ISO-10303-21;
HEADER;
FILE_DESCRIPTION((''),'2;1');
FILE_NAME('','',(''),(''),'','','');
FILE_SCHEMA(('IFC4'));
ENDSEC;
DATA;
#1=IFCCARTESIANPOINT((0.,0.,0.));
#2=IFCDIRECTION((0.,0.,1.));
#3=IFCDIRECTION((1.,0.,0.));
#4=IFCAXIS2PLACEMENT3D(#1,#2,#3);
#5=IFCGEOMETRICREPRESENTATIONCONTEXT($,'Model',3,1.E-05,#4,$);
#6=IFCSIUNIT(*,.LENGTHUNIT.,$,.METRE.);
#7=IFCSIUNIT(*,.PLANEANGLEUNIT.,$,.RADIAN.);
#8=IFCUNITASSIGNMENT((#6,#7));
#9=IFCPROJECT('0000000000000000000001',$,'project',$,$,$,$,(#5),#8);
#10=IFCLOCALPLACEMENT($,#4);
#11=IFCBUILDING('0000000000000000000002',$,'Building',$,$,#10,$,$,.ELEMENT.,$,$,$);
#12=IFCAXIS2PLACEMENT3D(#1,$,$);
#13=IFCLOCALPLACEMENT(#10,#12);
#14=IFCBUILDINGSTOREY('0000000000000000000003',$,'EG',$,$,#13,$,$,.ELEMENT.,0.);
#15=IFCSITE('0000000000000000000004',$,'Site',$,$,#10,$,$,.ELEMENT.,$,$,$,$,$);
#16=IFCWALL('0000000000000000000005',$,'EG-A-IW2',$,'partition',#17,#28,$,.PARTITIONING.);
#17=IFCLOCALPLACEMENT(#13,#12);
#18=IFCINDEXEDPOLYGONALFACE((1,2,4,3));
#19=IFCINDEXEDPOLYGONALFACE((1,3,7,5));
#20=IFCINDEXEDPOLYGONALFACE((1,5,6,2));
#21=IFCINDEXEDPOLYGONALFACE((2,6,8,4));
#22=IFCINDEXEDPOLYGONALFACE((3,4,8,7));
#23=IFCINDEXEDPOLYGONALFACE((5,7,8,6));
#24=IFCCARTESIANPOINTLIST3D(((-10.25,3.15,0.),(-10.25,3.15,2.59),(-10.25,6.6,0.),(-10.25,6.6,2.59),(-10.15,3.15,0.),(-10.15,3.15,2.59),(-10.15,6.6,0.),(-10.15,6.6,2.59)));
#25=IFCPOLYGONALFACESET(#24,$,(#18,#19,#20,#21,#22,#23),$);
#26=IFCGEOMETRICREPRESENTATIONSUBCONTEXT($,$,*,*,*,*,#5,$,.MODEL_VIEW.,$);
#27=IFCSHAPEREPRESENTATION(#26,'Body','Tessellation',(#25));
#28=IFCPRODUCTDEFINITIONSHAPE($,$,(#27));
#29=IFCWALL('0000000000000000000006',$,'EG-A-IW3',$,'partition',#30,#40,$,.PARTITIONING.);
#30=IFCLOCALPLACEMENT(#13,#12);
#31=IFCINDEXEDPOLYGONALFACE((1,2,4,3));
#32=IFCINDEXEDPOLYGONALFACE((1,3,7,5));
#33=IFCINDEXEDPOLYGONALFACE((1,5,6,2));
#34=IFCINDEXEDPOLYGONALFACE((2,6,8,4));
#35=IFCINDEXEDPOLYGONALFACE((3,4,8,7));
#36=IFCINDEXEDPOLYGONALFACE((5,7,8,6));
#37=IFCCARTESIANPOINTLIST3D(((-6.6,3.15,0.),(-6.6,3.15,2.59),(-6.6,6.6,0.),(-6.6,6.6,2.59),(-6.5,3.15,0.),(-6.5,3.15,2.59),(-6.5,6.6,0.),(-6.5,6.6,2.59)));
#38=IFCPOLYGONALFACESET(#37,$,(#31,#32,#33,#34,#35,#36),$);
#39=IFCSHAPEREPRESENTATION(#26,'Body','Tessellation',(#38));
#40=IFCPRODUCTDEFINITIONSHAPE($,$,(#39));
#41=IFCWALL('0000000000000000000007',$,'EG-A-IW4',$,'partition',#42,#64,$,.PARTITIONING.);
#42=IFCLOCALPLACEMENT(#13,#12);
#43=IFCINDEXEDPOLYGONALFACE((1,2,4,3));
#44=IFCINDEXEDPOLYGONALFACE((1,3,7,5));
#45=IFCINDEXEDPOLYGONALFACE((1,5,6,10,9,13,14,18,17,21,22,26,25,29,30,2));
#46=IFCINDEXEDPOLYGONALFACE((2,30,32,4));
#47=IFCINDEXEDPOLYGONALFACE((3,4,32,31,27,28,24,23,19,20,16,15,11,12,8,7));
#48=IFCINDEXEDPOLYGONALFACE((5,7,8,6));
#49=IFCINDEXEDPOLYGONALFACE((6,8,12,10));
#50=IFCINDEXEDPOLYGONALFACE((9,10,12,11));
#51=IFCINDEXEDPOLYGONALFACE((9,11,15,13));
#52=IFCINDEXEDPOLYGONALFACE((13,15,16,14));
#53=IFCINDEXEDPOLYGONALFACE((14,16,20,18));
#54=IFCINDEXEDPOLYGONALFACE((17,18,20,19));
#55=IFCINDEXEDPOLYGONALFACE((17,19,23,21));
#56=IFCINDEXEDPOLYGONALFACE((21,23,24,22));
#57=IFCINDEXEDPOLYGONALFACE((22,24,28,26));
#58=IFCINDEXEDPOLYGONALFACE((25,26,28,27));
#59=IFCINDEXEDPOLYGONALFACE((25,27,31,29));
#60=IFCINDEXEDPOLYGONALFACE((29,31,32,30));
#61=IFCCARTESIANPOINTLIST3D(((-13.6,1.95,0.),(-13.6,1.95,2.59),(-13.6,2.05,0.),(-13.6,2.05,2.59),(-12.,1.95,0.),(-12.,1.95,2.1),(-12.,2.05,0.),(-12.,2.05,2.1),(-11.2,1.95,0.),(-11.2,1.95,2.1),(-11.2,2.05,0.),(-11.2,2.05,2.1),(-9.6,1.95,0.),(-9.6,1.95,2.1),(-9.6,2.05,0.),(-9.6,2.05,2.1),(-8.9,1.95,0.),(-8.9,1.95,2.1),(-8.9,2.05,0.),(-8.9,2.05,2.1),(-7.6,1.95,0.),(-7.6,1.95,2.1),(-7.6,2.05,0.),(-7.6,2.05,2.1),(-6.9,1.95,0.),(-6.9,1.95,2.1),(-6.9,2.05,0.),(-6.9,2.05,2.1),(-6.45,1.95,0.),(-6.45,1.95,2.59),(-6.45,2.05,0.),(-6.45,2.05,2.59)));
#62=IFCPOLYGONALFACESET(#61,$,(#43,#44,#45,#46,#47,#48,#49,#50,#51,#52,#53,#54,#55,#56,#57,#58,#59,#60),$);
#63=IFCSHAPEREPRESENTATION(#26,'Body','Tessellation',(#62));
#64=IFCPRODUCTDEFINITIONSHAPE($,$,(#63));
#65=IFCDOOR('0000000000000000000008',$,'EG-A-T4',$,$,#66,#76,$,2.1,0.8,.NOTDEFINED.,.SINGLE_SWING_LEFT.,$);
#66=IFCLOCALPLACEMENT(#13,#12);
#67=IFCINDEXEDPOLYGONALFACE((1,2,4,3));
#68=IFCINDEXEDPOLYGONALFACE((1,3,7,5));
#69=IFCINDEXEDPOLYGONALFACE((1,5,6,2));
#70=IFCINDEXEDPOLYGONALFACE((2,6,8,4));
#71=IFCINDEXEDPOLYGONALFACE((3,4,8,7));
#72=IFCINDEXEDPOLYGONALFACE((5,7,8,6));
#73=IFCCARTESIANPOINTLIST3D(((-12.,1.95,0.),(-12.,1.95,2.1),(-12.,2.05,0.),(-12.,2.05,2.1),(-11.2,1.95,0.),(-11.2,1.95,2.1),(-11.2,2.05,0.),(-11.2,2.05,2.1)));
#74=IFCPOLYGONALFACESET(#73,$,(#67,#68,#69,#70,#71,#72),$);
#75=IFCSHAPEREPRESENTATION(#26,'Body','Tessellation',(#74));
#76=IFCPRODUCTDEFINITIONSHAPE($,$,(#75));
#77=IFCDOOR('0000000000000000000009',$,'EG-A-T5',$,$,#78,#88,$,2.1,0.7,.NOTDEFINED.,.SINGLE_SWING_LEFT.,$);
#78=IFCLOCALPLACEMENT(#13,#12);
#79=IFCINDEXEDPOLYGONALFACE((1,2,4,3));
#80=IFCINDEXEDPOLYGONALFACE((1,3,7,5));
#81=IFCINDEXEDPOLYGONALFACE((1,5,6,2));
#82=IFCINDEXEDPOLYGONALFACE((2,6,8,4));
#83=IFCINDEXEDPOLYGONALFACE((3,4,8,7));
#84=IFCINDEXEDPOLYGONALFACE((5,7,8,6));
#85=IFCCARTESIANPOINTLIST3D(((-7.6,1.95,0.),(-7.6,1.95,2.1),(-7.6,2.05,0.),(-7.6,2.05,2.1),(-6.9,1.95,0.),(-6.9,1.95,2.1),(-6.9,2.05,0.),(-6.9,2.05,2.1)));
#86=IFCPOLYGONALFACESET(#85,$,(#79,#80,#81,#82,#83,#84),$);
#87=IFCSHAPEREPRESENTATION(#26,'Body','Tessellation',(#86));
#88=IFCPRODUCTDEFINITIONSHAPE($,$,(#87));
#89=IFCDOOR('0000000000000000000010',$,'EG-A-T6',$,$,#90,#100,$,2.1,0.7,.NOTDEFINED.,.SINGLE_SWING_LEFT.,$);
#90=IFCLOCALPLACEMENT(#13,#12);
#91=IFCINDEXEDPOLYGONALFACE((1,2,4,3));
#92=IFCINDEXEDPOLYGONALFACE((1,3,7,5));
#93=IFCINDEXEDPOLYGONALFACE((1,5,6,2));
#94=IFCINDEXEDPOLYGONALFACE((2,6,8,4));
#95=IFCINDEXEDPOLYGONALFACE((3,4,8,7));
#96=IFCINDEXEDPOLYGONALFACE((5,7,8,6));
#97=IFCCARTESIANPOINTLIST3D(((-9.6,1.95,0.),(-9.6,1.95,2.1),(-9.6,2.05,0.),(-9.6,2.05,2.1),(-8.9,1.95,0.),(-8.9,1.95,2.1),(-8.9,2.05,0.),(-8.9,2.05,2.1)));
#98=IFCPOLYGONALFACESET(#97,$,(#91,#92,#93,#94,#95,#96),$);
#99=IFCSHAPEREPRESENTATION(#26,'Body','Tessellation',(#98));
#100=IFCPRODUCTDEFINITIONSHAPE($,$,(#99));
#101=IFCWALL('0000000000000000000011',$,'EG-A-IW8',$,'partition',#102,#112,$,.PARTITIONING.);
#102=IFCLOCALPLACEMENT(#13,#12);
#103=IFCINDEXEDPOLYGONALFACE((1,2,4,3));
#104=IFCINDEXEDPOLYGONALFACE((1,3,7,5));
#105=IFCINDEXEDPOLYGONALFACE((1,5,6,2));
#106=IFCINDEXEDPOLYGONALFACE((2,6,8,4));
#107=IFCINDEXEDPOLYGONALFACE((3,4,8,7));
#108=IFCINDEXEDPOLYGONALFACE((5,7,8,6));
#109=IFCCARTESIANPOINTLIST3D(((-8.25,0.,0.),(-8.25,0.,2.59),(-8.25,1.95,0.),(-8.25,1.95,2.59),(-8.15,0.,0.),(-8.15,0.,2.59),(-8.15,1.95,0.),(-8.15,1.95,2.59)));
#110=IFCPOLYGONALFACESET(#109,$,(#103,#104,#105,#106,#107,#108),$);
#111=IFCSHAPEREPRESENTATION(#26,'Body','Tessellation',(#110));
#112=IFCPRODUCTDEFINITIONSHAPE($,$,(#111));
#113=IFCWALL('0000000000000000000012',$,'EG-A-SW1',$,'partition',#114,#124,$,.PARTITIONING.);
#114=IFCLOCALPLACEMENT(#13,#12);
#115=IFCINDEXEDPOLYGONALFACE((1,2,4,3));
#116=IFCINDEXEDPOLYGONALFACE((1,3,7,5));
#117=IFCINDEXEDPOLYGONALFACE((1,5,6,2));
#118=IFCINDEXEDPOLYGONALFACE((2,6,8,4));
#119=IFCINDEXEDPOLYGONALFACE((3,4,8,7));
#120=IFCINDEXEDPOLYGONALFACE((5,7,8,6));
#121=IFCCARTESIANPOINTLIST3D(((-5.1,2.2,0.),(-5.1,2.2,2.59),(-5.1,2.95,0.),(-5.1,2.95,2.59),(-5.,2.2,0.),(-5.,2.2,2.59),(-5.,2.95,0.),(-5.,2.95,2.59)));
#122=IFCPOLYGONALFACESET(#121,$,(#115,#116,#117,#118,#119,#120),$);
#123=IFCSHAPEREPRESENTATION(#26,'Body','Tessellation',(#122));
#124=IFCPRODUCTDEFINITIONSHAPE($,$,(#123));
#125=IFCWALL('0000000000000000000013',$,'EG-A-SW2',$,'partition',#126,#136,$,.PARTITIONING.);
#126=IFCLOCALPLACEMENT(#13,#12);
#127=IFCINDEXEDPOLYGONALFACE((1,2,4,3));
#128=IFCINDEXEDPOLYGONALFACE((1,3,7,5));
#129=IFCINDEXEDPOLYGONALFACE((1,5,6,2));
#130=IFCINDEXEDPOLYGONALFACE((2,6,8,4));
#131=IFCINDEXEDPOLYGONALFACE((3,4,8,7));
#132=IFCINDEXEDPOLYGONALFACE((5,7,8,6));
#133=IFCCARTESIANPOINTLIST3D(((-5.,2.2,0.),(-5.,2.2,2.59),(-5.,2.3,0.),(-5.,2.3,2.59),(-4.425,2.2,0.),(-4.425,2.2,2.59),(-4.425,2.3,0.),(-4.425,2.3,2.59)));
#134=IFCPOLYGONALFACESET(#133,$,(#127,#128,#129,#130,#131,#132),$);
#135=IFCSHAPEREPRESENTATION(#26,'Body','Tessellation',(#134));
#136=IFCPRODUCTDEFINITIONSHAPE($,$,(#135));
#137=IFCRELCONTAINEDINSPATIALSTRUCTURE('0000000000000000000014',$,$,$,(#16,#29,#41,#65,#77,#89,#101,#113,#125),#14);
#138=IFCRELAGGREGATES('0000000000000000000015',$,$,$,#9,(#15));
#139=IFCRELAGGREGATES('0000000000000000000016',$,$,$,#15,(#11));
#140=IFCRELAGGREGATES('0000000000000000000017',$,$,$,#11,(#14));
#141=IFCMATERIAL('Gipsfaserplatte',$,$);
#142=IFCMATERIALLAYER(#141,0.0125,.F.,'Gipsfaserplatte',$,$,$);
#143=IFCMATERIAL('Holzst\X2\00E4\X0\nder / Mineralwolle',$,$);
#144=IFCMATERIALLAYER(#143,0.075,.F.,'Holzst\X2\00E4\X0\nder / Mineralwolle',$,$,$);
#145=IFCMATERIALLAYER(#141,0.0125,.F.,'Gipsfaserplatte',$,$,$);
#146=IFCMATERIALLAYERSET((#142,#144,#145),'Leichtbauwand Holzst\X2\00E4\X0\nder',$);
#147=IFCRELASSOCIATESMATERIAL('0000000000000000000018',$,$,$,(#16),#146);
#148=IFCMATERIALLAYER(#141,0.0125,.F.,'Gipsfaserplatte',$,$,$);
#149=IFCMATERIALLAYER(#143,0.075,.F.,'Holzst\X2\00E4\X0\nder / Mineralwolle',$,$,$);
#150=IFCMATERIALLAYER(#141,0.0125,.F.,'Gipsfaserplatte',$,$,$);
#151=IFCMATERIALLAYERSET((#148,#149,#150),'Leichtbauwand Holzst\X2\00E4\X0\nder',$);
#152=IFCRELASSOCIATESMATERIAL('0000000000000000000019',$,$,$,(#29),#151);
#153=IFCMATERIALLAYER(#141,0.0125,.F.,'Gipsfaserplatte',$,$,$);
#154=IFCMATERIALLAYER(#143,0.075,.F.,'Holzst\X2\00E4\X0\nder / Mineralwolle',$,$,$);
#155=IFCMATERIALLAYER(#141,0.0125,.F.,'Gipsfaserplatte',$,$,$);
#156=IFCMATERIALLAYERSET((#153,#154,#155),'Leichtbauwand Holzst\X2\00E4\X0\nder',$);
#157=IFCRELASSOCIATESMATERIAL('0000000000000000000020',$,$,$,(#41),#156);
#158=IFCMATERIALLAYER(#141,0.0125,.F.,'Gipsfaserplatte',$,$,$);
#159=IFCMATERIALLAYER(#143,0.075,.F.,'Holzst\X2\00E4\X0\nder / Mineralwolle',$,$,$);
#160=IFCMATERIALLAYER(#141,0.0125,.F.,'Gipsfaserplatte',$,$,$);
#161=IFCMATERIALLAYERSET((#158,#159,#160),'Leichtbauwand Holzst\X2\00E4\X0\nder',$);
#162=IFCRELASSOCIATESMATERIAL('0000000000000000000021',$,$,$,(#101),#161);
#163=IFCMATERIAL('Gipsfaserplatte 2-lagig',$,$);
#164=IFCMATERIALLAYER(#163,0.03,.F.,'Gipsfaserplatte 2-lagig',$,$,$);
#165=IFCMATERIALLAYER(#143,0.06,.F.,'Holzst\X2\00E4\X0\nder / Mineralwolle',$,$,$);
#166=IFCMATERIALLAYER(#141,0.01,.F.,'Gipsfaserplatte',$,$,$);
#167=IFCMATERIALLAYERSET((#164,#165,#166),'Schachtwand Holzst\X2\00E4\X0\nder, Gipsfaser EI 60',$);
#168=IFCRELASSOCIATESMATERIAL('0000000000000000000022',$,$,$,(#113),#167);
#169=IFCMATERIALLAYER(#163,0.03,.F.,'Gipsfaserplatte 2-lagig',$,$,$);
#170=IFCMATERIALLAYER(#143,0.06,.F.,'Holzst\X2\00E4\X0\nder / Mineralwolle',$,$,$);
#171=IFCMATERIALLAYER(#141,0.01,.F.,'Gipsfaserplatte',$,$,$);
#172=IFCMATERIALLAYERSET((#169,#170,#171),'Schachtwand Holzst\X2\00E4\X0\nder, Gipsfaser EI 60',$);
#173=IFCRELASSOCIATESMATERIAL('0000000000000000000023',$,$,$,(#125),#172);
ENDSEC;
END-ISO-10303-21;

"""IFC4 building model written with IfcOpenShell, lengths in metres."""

from ifc_helpers import new_model, si_unit, frame, frame_2d, origin, origin_with_axes, place, context, subcontext, project, spatial, rectangle, extrude, material, layer, layer_set, element, fill, save


model = new_model("IFC4")

# Units and contexts
model_context = context("Model", 3, precision=1e-05, world=origin_with_axes())
sub_context = subcontext(model_context, None, None, "MODEL_VIEW")
ifc_project = project(units=[si_unit("LENGTHUNIT", "METRE"), si_unit("PLANEANGLEUNIT", "RADIAN")], contexts=[model_context])

# Site, building, storey
placement = place(None, origin_with_axes())
site = spatial("IfcSite", under=ifc_project, at=placement, Name="Site", CompositionType="ELEMENT")
building = spatial("IfcBuilding", under=site, at=placement, Name="Building", CompositionType="ELEMENT")
storey_placement = place(placement, origin())
storey = spatial("IfcBuildingStorey", under=building, at=storey_placement, Name="EG", CompositionType="ELEMENT", Elevation=0.0)

# Shared definitions
ifc_material_1 = material(Name="Gipsfaserplatte")

# Shared definitions
ifc_material_2 = material(Name="Gipsfaserplatte 2-lagig")

# Walls
ifc_layer_1 = layer(ifc_material_1, 0.0125, ventilated=False, Name="Gipsfaserplatte")
ifc_material_3 = material(Name="Holzständer / Mineralwolle")
ifc_layer_2 = layer(ifc_material_3, 0.075, ventilated=False, Name="Holzständer / Mineralwolle")
ifc_layer_3 = layer(ifc_material_1, 0.0125, ventilated=False, Name="Gipsfaserplatte")
ifc_layer_set_1 = layer_set([ifc_layer_1, ifc_layer_2, ifc_layer_3], Name="Leichtbauwand Holzständer")
wall_1_placement = place(storey_placement, frame((-10.2, 3.15, 0.0), z_axis=(0.0, 0.0, 1.0), x_axis=(0.0, 1.0, 0.0)))
element("IfcWall", 1, at=wall_1_placement, inside=storey, material=ifc_layer_set_1, Name="EG-A-IW2", ObjectType="partition", PredefinedType="PARTITIONING", context=sub_context, shape_type="SweptSolid", body=[
    extrude(rectangle(XDim=3.45, YDim=0.1, at=frame_2d((1.725, 0.0))), origin(), (0.0, 0.0, 1.0), 2.59),
])
ifc_layer_4 = layer(ifc_material_1, 0.0125, ventilated=False, Name="Gipsfaserplatte")
ifc_layer_5 = layer(ifc_material_3, 0.075, ventilated=False, Name="Holzständer / Mineralwolle")
ifc_layer_6 = layer(ifc_material_1, 0.0125, ventilated=False, Name="Gipsfaserplatte")
ifc_layer_set_2 = layer_set([ifc_layer_4, ifc_layer_5, ifc_layer_6], Name="Leichtbauwand Holzständer")
wall_2_placement = place(storey_placement, frame((-6.55, 3.15, 0.0), z_axis=(0.0, 0.0, 1.0), x_axis=(0.0, 1.0, 0.0)))
element("IfcWall", 2, at=wall_2_placement, inside=storey, material=ifc_layer_set_2, Name="EG-A-IW3", ObjectType="partition", PredefinedType="PARTITIONING", context=sub_context, shape_type="SweptSolid", body=[
    extrude(rectangle(XDim=3.45, YDim=0.1, at=frame_2d((1.725, 0.0))), origin(), (0.0, 0.0, 1.0), 2.59),
])

# Wall, openings, doors
ifc_layer_7 = layer(ifc_material_1, 0.0125, ventilated=False, Name="Gipsfaserplatte")
ifc_layer_8 = layer(ifc_material_3, 0.075, ventilated=False, Name="Holzständer / Mineralwolle")
ifc_layer_9 = layer(ifc_material_1, 0.0125, ventilated=False, Name="Gipsfaserplatte")
ifc_layer_set_3 = layer_set([ifc_layer_7, ifc_layer_8, ifc_layer_9], Name="Leichtbauwand Holzständer")
wall_3_placement = place(storey_placement, frame((-13.6, 2.0, 0.0), z_axis=(0.0, 0.0, 1.0), x_axis=(1.0, 0.0, 0.0)))
wall_3 = element("IfcWall", 3, at=wall_3_placement, inside=storey, material=ifc_layer_set_3, Name="EG-A-IW4", ObjectType="partition", PredefinedType="PARTITIONING", context=sub_context, shape_type="SweptSolid", body=[
    extrude(rectangle(XDim=7.15, YDim=0.1, at=frame_2d((3.575, 0.0))), origin(), (0.0, 0.0, 1.0), 2.59),
])
opening_1_placement = place(wall_3_placement, frame((2.0, 0.1, 0.0), z_axis=(0.0, -1.0, 0.0), x_axis=(1.0, 0.0, 0.0)))
opening_1 = element("IfcOpeningElement", 4, at=opening_1_placement, cuts=wall_3, PredefinedType="OPENING", context=sub_context, shape_type="SweptSolid", body=[
    extrude(rectangle(XDim=0.8, YDim=2.1, at=frame_2d((0.0, 1.05))), origin(), (0.0, 0.0, 1.0), 0.2),
])
opening_2_placement = place(wall_3_placement, frame((6.35, 0.1, 0.0), z_axis=(0.0, -1.0, 0.0), x_axis=(1.0, 0.0, 0.0)))
opening_2 = element("IfcOpeningElement", 5, at=opening_2_placement, cuts=wall_3, PredefinedType="OPENING", context=sub_context, shape_type="SweptSolid", body=[
    extrude(rectangle(XDim=0.7, YDim=2.1, at=frame_2d((0.0, 1.05))), origin(), (0.0, 0.0, 1.0), 0.2),
])
opening_3_placement = place(wall_3_placement, frame((4.35, 0.1, 0.0), z_axis=(0.0, -1.0, 0.0), x_axis=(1.0, 0.0, 0.0)))
opening_3 = element("IfcOpeningElement", 6, at=opening_3_placement, cuts=wall_3, PredefinedType="OPENING", context=sub_context, shape_type="SweptSolid", body=[
    extrude(rectangle(XDim=0.7, YDim=2.1, at=frame_2d((0.0, 1.05))), origin(), (0.0, 0.0, 1.0), 0.2),
])
door_1_placement = place(wall_3_placement, frame((2.0, 0.05, 0.0), z_axis=(0.0, -1.0, 0.0), x_axis=(1.0, 0.0, 0.0)))
door_1 = element("IfcDoor", 7, at=door_1_placement, inside=storey, Name="EG-A-T4", OperationType="SINGLE_SWING_LEFT", OverallHeight=2.1, OverallWidth=0.8, PredefinedType="NOTDEFINED", context=sub_context, shape_type="SweptSolid", body=[
    extrude(rectangle(XDim=0.8, YDim=2.1, at=frame_2d((0.0, 1.05))), origin(), (0.0, 0.0, 1.0), 0.1),
])
fill(opening_1, door_1)
door_2_placement = place(wall_3_placement, frame((6.35, 0.05, 0.0), z_axis=(0.0, -1.0, 0.0), x_axis=(1.0, 0.0, 0.0)))
door_2 = element("IfcDoor", 8, at=door_2_placement, inside=storey, Name="EG-A-T5", OperationType="SINGLE_SWING_LEFT", OverallHeight=2.1, OverallWidth=0.7, PredefinedType="NOTDEFINED", context=sub_context, shape_type="SweptSolid", body=[
    extrude(rectangle(XDim=0.7, YDim=2.1, at=frame_2d((0.0, 1.05))), origin(), (0.0, 0.0, 1.0), 0.1),
])
fill(opening_2, door_2)
door_3_placement = place(wall_3_placement, frame((4.35, 0.05, 0.0), z_axis=(0.0, -1.0, 0.0), x_axis=(1.0, 0.0, 0.0)))
door_3 = element("IfcDoor", 9, at=door_3_placement, inside=storey, Name="EG-A-T6", OperationType="SINGLE_SWING_LEFT", OverallHeight=2.1, OverallWidth=0.7, PredefinedType="NOTDEFINED", context=sub_context, shape_type="SweptSolid", body=[
    extrude(rectangle(XDim=0.7, YDim=2.1, at=frame_2d((0.0, 1.05))), origin(), (0.0, 0.0, 1.0), 0.1),
])
fill(opening_3, door_3)

# Walls
ifc_layer_10 = layer(ifc_material_1, 0.0125, ventilated=False, Name="Gipsfaserplatte")
ifc_layer_11 = layer(ifc_material_3, 0.075, ventilated=False, Name="Holzständer / Mineralwolle")
ifc_layer_12 = layer(ifc_material_1, 0.0125, ventilated=False, Name="Gipsfaserplatte")
ifc_layer_set_4 = layer_set([ifc_layer_10, ifc_layer_11, ifc_layer_12], Name="Leichtbauwand Holzständer")
wall_4_placement = place(storey_placement, frame((-8.2, 0.0, 0.0), z_axis=(0.0, 0.0, 1.0), x_axis=(0.0, 1.0, 0.0)))
element("IfcWall", 10, at=wall_4_placement, inside=storey, material=ifc_layer_set_4, Name="EG-A-IW8", ObjectType="partition", PredefinedType="PARTITIONING", context=sub_context, shape_type="SweptSolid", body=[
    extrude(rectangle(XDim=1.95, YDim=0.1, at=frame_2d((0.975, 0.0))), origin(), (0.0, 0.0, 1.0), 2.59),
])
ifc_layer_13 = layer(ifc_material_2, 0.03, ventilated=False, Name="Gipsfaserplatte 2-lagig")
ifc_layer_14 = layer(ifc_material_3, 0.06, ventilated=False, Name="Holzständer / Mineralwolle")
ifc_layer_15 = layer(ifc_material_1, 0.01, ventilated=False, Name="Gipsfaserplatte")
ifc_layer_set_5 = layer_set([ifc_layer_13, ifc_layer_14, ifc_layer_15], Name="Schachtwand Holzständer, Gipsfaser EI 60")
wall_5_placement = place(storey_placement, frame((-5.05, 2.2, 0.0), z_axis=(0.0, 0.0, 1.0), x_axis=(0.0, 1.0, 0.0)))
element("IfcWall", 11, at=wall_5_placement, inside=storey, material=ifc_layer_set_5, Name="EG-A-SW1", ObjectType="partition", PredefinedType="PARTITIONING", context=sub_context, shape_type="SweptSolid", body=[
    extrude(rectangle(XDim=0.75, YDim=0.1, at=frame_2d((0.375, 0.0))), origin(), (0.0, 0.0, 1.0), 2.59),
])
ifc_layer_16 = layer(ifc_material_2, 0.03, ventilated=False, Name="Gipsfaserplatte 2-lagig")
ifc_layer_17 = layer(ifc_material_3, 0.06, ventilated=False, Name="Holzständer / Mineralwolle")
ifc_layer_18 = layer(ifc_material_1, 0.01, ventilated=False, Name="Gipsfaserplatte")
ifc_layer_set_6 = layer_set([ifc_layer_16, ifc_layer_17, ifc_layer_18], Name="Schachtwand Holzständer, Gipsfaser EI 60")
wall_6_placement = place(storey_placement, frame((-5.0, 2.25, 0.0), z_axis=(0.0, 0.0, 1.0), x_axis=(1.0, 0.0, 0.0)))
element("IfcWall", 12, at=wall_6_placement, inside=storey, material=ifc_layer_set_6, Name="EG-A-SW2", ObjectType="partition", PredefinedType="PARTITIONING", context=sub_context, shape_type="SweptSolid", body=[
    extrude(rectangle(XDim=0.575, YDim=0.1, at=frame_2d((0.2875, 0.0))), origin(), (0.0, 0.0, 1.0), 2.59),
])

save(model, "model.ifc")
